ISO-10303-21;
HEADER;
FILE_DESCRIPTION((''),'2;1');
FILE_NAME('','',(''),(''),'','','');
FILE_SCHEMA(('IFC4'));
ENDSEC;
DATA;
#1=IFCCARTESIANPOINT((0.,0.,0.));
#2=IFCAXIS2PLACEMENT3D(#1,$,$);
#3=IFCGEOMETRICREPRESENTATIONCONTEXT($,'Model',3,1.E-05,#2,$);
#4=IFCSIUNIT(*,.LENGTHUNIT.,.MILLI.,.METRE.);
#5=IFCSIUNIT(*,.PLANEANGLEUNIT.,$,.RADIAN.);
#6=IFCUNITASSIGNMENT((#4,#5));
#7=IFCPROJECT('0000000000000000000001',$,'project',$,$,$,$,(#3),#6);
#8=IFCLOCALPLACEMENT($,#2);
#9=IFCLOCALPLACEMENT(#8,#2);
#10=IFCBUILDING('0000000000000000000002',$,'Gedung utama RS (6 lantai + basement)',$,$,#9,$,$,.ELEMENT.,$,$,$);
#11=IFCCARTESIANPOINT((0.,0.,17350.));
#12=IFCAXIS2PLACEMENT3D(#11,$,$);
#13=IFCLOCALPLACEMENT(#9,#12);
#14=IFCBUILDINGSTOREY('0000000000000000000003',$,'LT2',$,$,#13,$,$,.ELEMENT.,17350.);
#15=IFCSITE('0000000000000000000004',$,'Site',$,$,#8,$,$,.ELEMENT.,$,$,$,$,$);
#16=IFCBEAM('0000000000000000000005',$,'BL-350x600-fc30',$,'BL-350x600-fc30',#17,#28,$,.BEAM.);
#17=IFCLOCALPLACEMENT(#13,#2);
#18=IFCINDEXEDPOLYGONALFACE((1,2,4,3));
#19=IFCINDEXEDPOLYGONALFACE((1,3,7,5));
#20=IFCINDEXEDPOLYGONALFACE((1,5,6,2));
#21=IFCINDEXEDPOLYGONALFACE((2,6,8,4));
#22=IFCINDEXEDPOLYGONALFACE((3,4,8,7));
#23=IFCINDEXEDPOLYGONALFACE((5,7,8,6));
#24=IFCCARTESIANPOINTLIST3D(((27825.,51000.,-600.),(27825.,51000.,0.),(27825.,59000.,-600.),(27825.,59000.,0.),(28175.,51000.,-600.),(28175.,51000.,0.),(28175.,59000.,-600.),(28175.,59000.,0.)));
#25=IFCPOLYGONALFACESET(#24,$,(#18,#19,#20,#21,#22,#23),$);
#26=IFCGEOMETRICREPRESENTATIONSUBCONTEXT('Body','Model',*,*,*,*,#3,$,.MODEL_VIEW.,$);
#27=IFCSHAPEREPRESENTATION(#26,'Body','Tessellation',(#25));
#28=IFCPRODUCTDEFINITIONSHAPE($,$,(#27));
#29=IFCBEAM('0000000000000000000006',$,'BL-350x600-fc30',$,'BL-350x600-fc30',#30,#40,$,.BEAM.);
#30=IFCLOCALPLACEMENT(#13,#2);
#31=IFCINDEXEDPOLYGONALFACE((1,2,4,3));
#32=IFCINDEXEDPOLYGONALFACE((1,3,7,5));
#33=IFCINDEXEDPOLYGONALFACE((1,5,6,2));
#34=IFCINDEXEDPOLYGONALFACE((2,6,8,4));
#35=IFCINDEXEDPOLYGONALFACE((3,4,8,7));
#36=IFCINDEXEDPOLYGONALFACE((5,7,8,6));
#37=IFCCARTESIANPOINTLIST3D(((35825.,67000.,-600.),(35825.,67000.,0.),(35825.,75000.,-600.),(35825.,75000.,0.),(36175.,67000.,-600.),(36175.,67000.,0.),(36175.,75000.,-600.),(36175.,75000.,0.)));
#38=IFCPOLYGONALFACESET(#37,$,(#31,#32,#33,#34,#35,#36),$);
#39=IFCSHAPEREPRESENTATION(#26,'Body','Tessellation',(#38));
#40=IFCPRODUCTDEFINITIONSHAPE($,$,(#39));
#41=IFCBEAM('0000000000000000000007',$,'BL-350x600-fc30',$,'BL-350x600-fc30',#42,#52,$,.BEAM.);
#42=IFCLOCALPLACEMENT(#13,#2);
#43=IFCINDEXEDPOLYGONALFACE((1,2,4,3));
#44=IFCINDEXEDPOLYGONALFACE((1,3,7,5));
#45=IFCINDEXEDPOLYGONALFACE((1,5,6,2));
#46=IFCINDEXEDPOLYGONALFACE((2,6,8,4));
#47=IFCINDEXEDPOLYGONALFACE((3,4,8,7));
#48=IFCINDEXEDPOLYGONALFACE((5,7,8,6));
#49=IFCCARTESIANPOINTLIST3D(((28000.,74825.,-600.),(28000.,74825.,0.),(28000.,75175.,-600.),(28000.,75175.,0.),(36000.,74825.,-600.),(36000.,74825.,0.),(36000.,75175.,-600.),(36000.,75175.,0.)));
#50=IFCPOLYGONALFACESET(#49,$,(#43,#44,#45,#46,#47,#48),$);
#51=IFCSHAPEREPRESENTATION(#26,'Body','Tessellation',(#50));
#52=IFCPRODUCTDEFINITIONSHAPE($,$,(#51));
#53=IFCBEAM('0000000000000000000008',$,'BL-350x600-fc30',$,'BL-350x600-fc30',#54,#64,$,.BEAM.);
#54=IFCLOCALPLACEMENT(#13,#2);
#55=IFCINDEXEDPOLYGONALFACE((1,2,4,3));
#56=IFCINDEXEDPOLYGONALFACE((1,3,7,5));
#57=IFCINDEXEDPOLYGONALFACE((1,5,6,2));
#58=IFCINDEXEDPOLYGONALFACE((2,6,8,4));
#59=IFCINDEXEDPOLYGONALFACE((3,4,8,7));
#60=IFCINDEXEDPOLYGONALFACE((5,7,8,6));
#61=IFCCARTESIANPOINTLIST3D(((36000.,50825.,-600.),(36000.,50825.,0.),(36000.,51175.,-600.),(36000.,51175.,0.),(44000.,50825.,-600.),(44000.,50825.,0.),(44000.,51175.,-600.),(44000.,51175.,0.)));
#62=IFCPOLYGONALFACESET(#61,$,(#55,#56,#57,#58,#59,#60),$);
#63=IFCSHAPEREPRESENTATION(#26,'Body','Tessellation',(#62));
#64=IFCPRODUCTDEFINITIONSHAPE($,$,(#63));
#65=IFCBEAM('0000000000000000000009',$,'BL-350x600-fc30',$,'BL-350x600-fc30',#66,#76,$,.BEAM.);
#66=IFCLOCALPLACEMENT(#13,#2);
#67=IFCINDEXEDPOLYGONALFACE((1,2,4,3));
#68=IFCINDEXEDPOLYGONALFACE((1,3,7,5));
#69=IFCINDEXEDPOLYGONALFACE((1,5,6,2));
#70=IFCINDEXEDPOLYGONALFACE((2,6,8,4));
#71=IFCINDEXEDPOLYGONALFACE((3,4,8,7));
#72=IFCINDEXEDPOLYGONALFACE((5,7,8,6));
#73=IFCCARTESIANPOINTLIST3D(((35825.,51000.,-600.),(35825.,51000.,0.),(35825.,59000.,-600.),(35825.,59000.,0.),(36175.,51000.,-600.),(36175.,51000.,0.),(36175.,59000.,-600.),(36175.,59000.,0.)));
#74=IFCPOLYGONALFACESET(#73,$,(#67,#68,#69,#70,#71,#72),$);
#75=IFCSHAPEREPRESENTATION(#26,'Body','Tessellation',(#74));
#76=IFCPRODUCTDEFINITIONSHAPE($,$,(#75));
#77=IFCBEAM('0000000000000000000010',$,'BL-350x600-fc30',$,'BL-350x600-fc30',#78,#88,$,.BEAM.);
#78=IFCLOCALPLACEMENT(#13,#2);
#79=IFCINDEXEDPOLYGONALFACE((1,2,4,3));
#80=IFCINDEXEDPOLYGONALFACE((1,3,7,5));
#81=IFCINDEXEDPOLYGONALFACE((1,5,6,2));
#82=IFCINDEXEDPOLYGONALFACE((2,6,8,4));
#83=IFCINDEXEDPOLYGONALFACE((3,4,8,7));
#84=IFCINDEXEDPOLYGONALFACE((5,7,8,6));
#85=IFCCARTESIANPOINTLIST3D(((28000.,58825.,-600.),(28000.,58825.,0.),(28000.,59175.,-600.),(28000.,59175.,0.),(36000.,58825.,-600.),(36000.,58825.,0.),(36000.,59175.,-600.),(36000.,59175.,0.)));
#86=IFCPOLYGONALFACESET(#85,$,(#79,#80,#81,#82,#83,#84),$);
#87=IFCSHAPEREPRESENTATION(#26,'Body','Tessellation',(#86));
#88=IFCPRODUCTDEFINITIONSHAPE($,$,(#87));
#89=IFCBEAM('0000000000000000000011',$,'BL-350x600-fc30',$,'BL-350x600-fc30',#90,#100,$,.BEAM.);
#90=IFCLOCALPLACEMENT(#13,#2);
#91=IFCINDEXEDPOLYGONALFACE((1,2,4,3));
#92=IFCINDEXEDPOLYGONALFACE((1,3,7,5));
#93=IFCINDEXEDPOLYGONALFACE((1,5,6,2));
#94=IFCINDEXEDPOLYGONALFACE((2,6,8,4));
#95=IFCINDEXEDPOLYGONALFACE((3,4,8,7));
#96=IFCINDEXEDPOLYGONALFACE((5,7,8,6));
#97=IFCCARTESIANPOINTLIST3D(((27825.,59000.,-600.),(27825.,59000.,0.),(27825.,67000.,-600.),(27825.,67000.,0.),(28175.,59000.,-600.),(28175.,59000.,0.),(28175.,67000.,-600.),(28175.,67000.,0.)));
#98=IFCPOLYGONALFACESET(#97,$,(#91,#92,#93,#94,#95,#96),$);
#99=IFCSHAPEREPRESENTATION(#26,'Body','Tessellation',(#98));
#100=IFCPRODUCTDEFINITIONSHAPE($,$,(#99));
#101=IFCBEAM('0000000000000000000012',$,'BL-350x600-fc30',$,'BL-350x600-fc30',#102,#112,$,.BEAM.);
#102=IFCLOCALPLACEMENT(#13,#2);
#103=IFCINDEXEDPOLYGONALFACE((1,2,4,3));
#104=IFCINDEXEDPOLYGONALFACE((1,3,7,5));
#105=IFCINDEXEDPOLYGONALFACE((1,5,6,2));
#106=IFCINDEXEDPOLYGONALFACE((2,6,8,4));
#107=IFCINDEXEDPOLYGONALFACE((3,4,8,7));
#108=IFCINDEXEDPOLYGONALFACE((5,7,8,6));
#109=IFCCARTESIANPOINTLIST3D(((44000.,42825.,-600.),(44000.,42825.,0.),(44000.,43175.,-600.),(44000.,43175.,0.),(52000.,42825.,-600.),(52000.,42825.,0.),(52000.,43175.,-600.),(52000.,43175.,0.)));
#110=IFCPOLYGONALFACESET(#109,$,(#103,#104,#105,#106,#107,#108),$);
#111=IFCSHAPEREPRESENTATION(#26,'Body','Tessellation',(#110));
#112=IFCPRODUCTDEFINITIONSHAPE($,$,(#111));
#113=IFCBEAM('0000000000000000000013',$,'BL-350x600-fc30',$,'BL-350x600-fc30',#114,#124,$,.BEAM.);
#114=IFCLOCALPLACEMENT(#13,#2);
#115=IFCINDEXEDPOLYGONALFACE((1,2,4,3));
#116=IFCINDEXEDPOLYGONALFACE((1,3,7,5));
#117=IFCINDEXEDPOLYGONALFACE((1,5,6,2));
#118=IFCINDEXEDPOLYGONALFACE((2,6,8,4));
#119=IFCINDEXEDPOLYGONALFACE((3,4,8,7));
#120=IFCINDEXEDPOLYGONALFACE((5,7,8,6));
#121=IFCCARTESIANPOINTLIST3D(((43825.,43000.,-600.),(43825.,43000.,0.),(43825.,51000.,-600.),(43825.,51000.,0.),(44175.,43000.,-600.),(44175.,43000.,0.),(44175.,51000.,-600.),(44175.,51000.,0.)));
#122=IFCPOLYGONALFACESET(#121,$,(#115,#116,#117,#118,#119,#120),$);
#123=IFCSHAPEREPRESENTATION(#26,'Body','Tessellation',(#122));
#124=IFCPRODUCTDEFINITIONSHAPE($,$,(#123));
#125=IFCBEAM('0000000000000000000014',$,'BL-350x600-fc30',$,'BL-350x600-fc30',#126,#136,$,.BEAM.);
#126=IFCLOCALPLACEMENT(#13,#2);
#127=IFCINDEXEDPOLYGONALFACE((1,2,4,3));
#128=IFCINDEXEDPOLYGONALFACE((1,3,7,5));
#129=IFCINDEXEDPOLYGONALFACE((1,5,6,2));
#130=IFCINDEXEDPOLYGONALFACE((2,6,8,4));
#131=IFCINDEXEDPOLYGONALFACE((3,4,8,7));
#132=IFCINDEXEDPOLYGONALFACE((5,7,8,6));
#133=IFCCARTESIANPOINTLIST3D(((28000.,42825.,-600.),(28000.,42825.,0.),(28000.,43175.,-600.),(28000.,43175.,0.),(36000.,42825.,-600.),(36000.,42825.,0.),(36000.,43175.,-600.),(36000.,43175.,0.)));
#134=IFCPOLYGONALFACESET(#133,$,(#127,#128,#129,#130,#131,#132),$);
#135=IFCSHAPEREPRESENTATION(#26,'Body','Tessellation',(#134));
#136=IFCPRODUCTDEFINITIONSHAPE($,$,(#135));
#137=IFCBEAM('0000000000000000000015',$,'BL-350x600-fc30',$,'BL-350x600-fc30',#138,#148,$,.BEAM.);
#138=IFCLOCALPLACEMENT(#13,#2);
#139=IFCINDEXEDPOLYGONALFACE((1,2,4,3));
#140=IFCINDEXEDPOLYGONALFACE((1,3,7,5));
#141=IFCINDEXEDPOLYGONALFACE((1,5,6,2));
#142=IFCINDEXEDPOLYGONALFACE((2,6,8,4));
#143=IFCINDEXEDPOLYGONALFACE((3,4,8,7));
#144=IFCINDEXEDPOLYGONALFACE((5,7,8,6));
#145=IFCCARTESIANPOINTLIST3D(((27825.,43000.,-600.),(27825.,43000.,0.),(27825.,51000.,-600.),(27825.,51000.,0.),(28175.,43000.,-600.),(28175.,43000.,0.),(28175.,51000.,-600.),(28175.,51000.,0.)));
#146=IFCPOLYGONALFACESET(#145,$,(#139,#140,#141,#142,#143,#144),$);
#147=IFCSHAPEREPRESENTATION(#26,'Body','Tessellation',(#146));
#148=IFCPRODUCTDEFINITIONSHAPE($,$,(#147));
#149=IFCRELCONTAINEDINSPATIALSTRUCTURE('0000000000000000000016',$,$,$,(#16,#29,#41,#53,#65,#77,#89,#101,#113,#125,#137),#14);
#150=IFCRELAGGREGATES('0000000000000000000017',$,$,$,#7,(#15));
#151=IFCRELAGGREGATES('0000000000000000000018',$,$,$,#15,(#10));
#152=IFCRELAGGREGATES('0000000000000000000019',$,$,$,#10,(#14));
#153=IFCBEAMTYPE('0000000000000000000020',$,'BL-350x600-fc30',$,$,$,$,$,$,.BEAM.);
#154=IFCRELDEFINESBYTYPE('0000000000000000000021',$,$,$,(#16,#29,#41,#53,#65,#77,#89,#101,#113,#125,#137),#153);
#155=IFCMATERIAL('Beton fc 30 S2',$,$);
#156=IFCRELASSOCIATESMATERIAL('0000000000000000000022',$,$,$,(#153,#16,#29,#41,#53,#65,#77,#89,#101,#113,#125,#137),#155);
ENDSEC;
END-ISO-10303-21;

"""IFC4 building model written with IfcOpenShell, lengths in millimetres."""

from ifc_helpers import new_model, si_unit, frame, origin, origin_2d, place, context, subcontext, project, spatial, rectangle, extrude, material, material_profile, profile_set, profile_usage, type_object, element, save


model = new_model("IFC4")

# Units and contexts
model_context = context("Model", 3, precision=1e-05, world=origin())
body_context = subcontext(model_context, "Body", "Model", "MODEL_VIEW")
ifc_project = project(units=[si_unit("LENGTHUNIT", "METRE", prefix="MILLI"), si_unit("PLANEANGLEUNIT", "RADIAN")], contexts=[model_context])

# Site, building, storey
site_placement = place(None, origin())
site = spatial("IfcSite", under=ifc_project, at=site_placement, Name="Site", CompositionType="ELEMENT")
building_placement = place(site_placement, origin())
building = spatial("IfcBuilding", under=site, at=building_placement, Name="Gedung utama RS (6 lantai + basement)", CompositionType="ELEMENT")
storey_placement = place(building_placement, frame((0.0, 0.0, 17350.0)))
storey = spatial("IfcBuildingStorey", under=building, at=storey_placement, Name="LT2", CompositionType="ELEMENT", Elevation=17350.0)

# Beams
ifc_material = material(Name="Beton fc 30 S2")
ifc_material_profile_1 = material_profile(ifc_material, rectangle(XDim=350.0, YDim=600.0, at=origin_2d()), Name="BL-350x600-fc30")
ifc_profile_set_1 = profile_set([ifc_material_profile_1], Name="BL-350x600-fc30")
ifc_profile_usage_1 = profile_usage(ifc_profile_set_1, cardinal=8)
beam_type = type_object("IfcBeamType", Name="BL-350x600-fc30", PredefinedType="BEAM", material=ifc_profile_set_1)
for number, where, name in (
    (1, (28000.0, 51000.0, -300.0), "BL-350x600-fc30"),
    (2, (36000.0, 67000.0, -300.0), "BL-350x600-fc30"),
):
    element("IfcBeam", number, at=place(storey_placement, frame(where)), inside=storey, type_object=beam_type, material=ifc_profile_usage_1, Name=name, ObjectType="BL-350x600-fc30", PredefinedType="BEAM", context=body_context, shape_type="SweptSolid", body=[
        extrude(rectangle(XDim=350.0, YDim=600.0, at=origin_2d()), frame((0.0, 0.0, 0.0), z_axis=(0.0, 1.0, 0.0), x_axis=(-1.0, 0.0, 0.0)), (0.0, 0.0, 1.0), 8000.0),
    ])
for number, where, name in (
    (3, (28000.0, 75000.0, -300.0), "BL-350x600-fc30"),
    (4, (36000.0, 51000.0, -300.0), "BL-350x600-fc30"),
):
    element("IfcBeam", number, at=place(storey_placement, frame(where)), inside=storey, type_object=beam_type, material=ifc_profile_usage_1, Name=name, ObjectType="BL-350x600-fc30", PredefinedType="BEAM", context=body_context, shape_type="SweptSolid", body=[
        extrude(rectangle(XDim=350.0, YDim=600.0, at=origin_2d()), frame((0.0, 0.0, 0.0), z_axis=(1.0, 0.0, 0.0), x_axis=(0.0, 1.0, 0.0)), (0.0, 0.0, 1.0), 8000.0),
    ])
beam_1_placement = place(storey_placement, frame((36000.0, 51000.0, -300.0)))
element("IfcBeam", 5, at=beam_1_placement, inside=storey, type_object=beam_type, material=ifc_profile_usage_1, Name="BL-350x600-fc30", ObjectType="BL-350x600-fc30", PredefinedType="BEAM", context=body_context, shape_type="SweptSolid", body=[
    extrude(rectangle(XDim=350.0, YDim=600.0, at=origin_2d()), frame((0.0, 0.0, 0.0), z_axis=(0.0, 1.0, 0.0), x_axis=(-1.0, 0.0, 0.0)), (0.0, 0.0, 1.0), 8000.0),
])
beam_2_placement = place(storey_placement, frame((28000.0, 59000.0, -300.0)))
element("IfcBeam", 6, at=beam_2_placement, inside=storey, type_object=beam_type, material=ifc_profile_usage_1, Name="BL-350x600-fc30", ObjectType="BL-350x600-fc30", PredefinedType="BEAM", context=body_context, shape_type="SweptSolid", body=[
    extrude(rectangle(XDim=350.0, YDim=600.0, at=origin_2d()), frame((0.0, 0.0, 0.0), z_axis=(1.0, 0.0, 0.0), x_axis=(0.0, 1.0, 0.0)), (0.0, 0.0, 1.0), 8000.0),
])
beam_3_placement = place(storey_placement, frame((28000.0, 59000.0, -300.0)))
element("IfcBeam", 7, at=beam_3_placement, inside=storey, type_object=beam_type, material=ifc_profile_usage_1, Name="BL-350x600-fc30", ObjectType="BL-350x600-fc30", PredefinedType="BEAM", context=body_context, shape_type="SweptSolid", body=[
    extrude(rectangle(XDim=350.0, YDim=600.0, at=origin_2d()), frame((0.0, 0.0, 0.0), z_axis=(0.0, 1.0, 0.0), x_axis=(-1.0, 0.0, 0.0)), (0.0, 0.0, 1.0), 8000.0),
])
beam_4_placement = place(storey_placement, frame((44000.0, 43000.0, -300.0)))
element("IfcBeam", 8, at=beam_4_placement, inside=storey, type_object=beam_type, material=ifc_profile_usage_1, Name="BL-350x600-fc30", ObjectType="BL-350x600-fc30", PredefinedType="BEAM", context=body_context, shape_type="SweptSolid", body=[
    extrude(rectangle(XDim=350.0, YDim=600.0, at=origin_2d()), frame((0.0, 0.0, 0.0), z_axis=(1.0, 0.0, 0.0), x_axis=(0.0, 1.0, 0.0)), (0.0, 0.0, 1.0), 8000.0),
])
beam_5_placement = place(storey_placement, frame((44000.0, 43000.0, -300.0)))
element("IfcBeam", 9, at=beam_5_placement, inside=storey, type_object=beam_type, material=ifc_profile_usage_1, Name="BL-350x600-fc30", ObjectType="BL-350x600-fc30", PredefinedType="BEAM", context=body_context, shape_type="SweptSolid", body=[
    extrude(rectangle(XDim=350.0, YDim=600.0, at=origin_2d()), frame((0.0, 0.0, 0.0), z_axis=(0.0, 1.0, 0.0), x_axis=(-1.0, 0.0, 0.0)), (0.0, 0.0, 1.0), 8000.0),
])
beam_6_placement = place(storey_placement, frame((28000.0, 43000.0, -300.0)))
element("IfcBeam", 10, at=beam_6_placement, inside=storey, type_object=beam_type, material=ifc_profile_usage_1, Name="BL-350x600-fc30", ObjectType="BL-350x600-fc30", PredefinedType="BEAM", context=body_context, shape_type="SweptSolid", body=[
    extrude(rectangle(XDim=350.0, YDim=600.0, at=origin_2d()), frame((0.0, 0.0, 0.0), z_axis=(1.0, 0.0, 0.0), x_axis=(0.0, 1.0, 0.0)), (0.0, 0.0, 1.0), 8000.0),
])
beam_7_placement = place(storey_placement, frame((28000.0, 43000.0, -300.0)))
element("IfcBeam", 11, at=beam_7_placement, inside=storey, type_object=beam_type, material=ifc_profile_usage_1, Name="BL-350x600-fc30", ObjectType="BL-350x600-fc30", PredefinedType="BEAM", context=body_context, shape_type="SweptSolid", body=[
    extrude(rectangle(XDim=350.0, YDim=600.0, at=origin_2d()), frame((0.0, 0.0, 0.0), z_axis=(0.0, 1.0, 0.0), x_axis=(-1.0, 0.0, 0.0)), (0.0, 0.0, 1.0), 8000.0),
])

save(model, "model.ifc")
